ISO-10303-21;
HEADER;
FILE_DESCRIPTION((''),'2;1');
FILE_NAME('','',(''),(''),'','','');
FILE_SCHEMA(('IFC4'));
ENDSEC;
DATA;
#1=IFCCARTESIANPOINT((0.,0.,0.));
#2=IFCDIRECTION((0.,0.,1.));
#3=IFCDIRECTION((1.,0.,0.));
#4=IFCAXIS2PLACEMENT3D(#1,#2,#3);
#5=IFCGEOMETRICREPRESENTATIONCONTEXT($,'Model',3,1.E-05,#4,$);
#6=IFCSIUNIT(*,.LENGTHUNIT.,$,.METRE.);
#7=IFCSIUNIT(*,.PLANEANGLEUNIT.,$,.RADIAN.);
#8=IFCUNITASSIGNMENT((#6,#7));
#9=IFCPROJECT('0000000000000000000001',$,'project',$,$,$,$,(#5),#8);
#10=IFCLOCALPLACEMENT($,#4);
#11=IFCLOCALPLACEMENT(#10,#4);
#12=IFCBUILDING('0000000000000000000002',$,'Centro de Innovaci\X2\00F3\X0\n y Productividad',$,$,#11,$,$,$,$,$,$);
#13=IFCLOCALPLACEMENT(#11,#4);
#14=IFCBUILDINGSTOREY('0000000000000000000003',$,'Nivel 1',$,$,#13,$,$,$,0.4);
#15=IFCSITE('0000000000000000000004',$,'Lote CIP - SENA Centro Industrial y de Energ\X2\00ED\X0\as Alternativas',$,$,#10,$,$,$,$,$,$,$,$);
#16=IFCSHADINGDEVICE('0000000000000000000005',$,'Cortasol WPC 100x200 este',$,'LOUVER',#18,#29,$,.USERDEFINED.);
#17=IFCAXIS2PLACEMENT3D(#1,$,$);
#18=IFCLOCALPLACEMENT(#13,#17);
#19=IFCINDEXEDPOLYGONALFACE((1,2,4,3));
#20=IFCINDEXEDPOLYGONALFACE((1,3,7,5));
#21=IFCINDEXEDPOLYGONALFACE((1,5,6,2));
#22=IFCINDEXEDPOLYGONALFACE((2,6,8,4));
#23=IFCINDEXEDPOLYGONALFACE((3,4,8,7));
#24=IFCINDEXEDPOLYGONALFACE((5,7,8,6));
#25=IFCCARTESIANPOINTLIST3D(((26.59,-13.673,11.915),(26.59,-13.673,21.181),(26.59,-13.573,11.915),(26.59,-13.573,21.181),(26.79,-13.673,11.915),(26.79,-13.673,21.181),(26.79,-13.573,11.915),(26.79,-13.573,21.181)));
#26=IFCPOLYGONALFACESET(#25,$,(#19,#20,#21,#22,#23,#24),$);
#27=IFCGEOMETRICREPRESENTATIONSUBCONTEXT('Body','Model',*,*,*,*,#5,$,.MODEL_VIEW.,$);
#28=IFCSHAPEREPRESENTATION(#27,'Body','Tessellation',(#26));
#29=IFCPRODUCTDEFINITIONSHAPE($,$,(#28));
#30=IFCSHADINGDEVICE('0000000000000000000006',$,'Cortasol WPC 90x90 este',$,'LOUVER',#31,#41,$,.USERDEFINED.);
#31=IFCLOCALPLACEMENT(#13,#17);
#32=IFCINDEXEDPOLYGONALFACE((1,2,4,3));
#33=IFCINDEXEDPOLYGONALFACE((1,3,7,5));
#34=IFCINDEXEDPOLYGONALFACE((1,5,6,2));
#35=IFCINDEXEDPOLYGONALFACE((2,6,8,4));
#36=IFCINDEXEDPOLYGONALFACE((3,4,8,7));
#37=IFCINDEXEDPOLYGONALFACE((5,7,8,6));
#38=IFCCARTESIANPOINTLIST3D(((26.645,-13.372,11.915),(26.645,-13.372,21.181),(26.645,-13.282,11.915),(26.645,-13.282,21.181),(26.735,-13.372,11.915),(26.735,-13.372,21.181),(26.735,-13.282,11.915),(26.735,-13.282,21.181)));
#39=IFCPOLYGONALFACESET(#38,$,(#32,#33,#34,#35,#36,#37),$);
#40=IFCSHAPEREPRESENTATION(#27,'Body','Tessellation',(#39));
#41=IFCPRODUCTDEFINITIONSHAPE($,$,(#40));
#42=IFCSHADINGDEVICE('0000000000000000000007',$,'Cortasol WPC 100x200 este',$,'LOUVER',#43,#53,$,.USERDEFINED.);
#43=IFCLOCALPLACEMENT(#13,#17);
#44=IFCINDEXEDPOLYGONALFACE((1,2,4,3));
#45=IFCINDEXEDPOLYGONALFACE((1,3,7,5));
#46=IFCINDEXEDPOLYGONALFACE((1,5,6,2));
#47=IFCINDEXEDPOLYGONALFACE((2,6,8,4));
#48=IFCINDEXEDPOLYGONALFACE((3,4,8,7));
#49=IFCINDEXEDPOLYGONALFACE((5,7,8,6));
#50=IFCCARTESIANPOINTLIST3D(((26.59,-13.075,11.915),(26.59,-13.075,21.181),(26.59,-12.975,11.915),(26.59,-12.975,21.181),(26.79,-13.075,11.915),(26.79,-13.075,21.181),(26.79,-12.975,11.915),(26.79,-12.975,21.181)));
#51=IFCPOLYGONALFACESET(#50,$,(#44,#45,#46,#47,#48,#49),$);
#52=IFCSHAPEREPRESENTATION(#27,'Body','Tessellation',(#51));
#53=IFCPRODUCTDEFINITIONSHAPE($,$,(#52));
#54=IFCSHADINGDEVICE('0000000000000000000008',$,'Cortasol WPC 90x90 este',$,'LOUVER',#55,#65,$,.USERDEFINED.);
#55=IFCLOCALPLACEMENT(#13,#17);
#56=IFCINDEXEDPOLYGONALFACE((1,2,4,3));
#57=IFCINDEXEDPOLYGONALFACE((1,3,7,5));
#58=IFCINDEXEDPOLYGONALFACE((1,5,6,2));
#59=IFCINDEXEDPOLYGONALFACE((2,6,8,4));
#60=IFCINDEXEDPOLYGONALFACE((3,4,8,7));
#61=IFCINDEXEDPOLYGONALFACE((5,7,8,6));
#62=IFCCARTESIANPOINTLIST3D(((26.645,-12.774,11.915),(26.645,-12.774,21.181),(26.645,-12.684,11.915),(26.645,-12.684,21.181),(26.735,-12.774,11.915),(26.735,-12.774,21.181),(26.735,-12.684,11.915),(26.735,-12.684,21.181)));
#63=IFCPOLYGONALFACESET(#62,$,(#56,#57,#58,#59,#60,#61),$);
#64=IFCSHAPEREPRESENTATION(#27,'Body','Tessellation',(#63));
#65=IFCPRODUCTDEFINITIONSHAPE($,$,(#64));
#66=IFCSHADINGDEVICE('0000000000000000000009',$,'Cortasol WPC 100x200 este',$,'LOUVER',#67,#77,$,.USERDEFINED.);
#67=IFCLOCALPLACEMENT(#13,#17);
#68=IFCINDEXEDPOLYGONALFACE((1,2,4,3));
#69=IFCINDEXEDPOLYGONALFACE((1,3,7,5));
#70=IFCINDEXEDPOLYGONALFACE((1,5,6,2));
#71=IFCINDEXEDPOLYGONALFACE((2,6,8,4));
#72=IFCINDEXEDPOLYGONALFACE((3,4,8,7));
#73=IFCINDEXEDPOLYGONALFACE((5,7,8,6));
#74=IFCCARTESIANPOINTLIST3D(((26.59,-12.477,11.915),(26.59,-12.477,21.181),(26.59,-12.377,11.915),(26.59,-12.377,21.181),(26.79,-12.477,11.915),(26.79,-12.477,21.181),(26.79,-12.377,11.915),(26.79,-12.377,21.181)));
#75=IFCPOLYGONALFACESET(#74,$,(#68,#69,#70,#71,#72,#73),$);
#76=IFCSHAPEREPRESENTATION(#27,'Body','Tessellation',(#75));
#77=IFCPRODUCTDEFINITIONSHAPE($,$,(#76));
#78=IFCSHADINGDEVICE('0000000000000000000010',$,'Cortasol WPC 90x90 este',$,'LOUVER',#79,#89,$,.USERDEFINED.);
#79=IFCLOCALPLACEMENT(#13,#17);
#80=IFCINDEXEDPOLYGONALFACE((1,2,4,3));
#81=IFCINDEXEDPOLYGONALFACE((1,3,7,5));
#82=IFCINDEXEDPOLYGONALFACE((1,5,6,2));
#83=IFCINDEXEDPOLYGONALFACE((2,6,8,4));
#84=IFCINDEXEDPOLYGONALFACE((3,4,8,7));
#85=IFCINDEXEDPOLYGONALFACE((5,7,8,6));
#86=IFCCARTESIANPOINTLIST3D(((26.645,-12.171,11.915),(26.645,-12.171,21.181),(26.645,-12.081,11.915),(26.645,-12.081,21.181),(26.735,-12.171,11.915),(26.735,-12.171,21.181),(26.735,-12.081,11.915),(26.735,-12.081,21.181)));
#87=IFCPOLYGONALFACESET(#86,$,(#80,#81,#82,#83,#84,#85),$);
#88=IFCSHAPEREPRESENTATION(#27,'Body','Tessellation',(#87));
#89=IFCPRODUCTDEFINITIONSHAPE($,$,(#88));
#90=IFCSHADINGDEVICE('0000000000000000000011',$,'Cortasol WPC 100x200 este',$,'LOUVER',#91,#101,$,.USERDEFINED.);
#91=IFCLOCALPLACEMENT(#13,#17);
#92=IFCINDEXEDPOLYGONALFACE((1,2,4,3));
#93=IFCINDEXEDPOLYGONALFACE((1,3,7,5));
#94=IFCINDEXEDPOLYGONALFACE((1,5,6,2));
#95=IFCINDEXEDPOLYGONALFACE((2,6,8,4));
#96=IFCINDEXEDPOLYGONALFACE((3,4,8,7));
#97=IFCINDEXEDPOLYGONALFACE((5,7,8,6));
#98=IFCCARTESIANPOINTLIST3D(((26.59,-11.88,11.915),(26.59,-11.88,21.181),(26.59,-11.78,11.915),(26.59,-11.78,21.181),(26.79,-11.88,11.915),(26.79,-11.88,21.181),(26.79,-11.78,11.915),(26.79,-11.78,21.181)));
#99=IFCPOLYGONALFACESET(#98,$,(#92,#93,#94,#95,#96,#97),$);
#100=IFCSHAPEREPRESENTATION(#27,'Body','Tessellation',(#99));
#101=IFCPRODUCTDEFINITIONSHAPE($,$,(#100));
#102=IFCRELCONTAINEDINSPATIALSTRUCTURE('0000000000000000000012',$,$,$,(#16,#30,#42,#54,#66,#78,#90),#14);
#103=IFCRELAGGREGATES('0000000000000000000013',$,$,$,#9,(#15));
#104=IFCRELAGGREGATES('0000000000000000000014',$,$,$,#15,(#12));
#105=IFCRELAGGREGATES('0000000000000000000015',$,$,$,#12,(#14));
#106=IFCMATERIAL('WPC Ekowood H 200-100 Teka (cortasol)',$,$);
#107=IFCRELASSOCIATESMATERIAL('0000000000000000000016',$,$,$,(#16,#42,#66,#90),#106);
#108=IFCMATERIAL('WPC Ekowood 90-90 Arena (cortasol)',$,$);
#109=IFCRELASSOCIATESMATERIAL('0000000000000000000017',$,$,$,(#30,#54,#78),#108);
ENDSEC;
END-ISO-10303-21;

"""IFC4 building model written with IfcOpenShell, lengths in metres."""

from ifc_helpers import new_model, si_unit, frame, origin_with_axes, place, context, subcontext, project, spatial, polyline, outline, extrude, material, element, save


model = new_model("IFC4")

# Units and contexts
model_context = context("Model", 3, precision=1e-05, world=origin_with_axes())
body_context = subcontext(model_context, "Body", "Model", "MODEL_VIEW")
ifc_project = project(units=[si_unit("LENGTHUNIT", "METRE"), si_unit("PLANEANGLEUNIT", "RADIAN")], contexts=[model_context])

# Site, building, storey
site_placement = place(None, origin_with_axes())
site = spatial("IfcSite", under=ifc_project, at=site_placement, Name="Lote CIP - SENA Centro Industrial y de Energías Alternativas")
building_placement = place(site_placement, origin_with_axes())
building = spatial("IfcBuilding", under=site, at=building_placement, Name="Centro de Innovación y Productividad")
storey_placement = place(building_placement, origin_with_axes())
storey = spatial("IfcBuildingStorey", under=building, at=storey_placement, Name="Nivel 1", Elevation=0.4)

# Shading devices
ifc_material_1 = material(Name="WPC Ekowood 90-90 Arena (cortasol)")
ifc_material_2 = material(Name="WPC Ekowood H 200-100 Teka (cortasol)")
shading_device_1_placement = place(storey_placement, origin_with_axes())
element("IfcShadingDevice", 1, at=shading_device_1_placement, inside=storey, material=ifc_material_2, Name="Cortasol WPC 100x200 este", ObjectType="LOUVER", PredefinedType="USERDEFINED", context=body_context, shape_type="SweptSolid", body=[
    extrude(outline(polyline([(26.79, -13.673), (26.59, -13.673), (26.59, -13.573), (26.79, -13.573), (26.79, -13.673)])), frame((0.0, 0.0, 11.915)), (0.0, 0.0, 1.0), 9.266),
])
shading_device_2_placement = place(storey_placement, origin_with_axes())
element("IfcShadingDevice", 2, at=shading_device_2_placement, inside=storey, material=ifc_material_1, Name="Cortasol WPC 90x90 este", ObjectType="LOUVER", PredefinedType="USERDEFINED", context=body_context, shape_type="SweptSolid", body=[
    extrude(outline(polyline([(26.735, -13.372), (26.645, -13.372), (26.645, -13.282), (26.735, -13.282), (26.735, -13.372)])), frame((0.0, 0.0, 11.915)), (0.0, 0.0, 1.0), 9.266),
])
shading_device_3_placement = place(storey_placement, origin_with_axes())
element("IfcShadingDevice", 3, at=shading_device_3_placement, inside=storey, material=ifc_material_2, Name="Cortasol WPC 100x200 este", ObjectType="LOUVER", PredefinedType="USERDEFINED", context=body_context, shape_type="SweptSolid", body=[
    extrude(outline(polyline([(26.79, -13.075), (26.59, -13.075), (26.59, -12.975), (26.79, -12.975), (26.79, -13.075)])), frame((0.0, 0.0, 11.915)), (0.0, 0.0, 1.0), 9.266),
])
shading_device_4_placement = place(storey_placement, origin_with_axes())
element("IfcShadingDevice", 4, at=shading_device_4_placement, inside=storey, material=ifc_material_1, Name="Cortasol WPC 90x90 este", ObjectType="LOUVER", PredefinedType="USERDEFINED", context=body_context, shape_type="SweptSolid", body=[
    extrude(outline(polyline([(26.735, -12.774), (26.645, -12.774), (26.645, -12.684), (26.735, -12.684), (26.735, -12.774)])), frame((0.0, 0.0, 11.915)), (0.0, 0.0, 1.0), 9.266),
])
shading_device_5_placement = place(storey_placement, origin_with_axes())
element("IfcShadingDevice", 5, at=shading_device_5_placement, inside=storey, material=ifc_material_2, Name="Cortasol WPC 100x200 este", ObjectType="LOUVER", PredefinedType="USERDEFINED", context=body_context, shape_type="SweptSolid", body=[
    extrude(outline(polyline([(26.79, -12.477), (26.59, -12.477), (26.59, -12.377), (26.79, -12.377), (26.79, -12.477)])), frame((0.0, 0.0, 11.915)), (0.0, 0.0, 1.0), 9.266),
])
shading_device_6_placement = place(storey_placement, origin_with_axes())
element("IfcShadingDevice", 6, at=shading_device_6_placement, inside=storey, material=ifc_material_1, Name="Cortasol WPC 90x90 este", ObjectType="LOUVER", PredefinedType="USERDEFINED", context=body_context, shape_type="SweptSolid", body=[
    extrude(outline(polyline([(26.735, -12.171), (26.645, -12.171), (26.645, -12.081), (26.735, -12.081), (26.735, -12.171)])), frame((0.0, 0.0, 11.915)), (0.0, 0.0, 1.0), 9.266),
])
shading_device_7_placement = place(storey_placement, origin_with_axes())
element("IfcShadingDevice", 7, at=shading_device_7_placement, inside=storey, material=ifc_material_2, Name="Cortasol WPC 100x200 este", ObjectType="LOUVER", PredefinedType="USERDEFINED", context=body_context, shape_type="SweptSolid", body=[
    extrude(outline(polyline([(26.79, -11.88), (26.59, -11.88), (26.59, -11.78), (26.79, -11.78), (26.79, -11.88)])), frame((0.0, 0.0, 11.915)), (0.0, 0.0, 1.0), 9.266),
])

save(model, "model.ifc")
